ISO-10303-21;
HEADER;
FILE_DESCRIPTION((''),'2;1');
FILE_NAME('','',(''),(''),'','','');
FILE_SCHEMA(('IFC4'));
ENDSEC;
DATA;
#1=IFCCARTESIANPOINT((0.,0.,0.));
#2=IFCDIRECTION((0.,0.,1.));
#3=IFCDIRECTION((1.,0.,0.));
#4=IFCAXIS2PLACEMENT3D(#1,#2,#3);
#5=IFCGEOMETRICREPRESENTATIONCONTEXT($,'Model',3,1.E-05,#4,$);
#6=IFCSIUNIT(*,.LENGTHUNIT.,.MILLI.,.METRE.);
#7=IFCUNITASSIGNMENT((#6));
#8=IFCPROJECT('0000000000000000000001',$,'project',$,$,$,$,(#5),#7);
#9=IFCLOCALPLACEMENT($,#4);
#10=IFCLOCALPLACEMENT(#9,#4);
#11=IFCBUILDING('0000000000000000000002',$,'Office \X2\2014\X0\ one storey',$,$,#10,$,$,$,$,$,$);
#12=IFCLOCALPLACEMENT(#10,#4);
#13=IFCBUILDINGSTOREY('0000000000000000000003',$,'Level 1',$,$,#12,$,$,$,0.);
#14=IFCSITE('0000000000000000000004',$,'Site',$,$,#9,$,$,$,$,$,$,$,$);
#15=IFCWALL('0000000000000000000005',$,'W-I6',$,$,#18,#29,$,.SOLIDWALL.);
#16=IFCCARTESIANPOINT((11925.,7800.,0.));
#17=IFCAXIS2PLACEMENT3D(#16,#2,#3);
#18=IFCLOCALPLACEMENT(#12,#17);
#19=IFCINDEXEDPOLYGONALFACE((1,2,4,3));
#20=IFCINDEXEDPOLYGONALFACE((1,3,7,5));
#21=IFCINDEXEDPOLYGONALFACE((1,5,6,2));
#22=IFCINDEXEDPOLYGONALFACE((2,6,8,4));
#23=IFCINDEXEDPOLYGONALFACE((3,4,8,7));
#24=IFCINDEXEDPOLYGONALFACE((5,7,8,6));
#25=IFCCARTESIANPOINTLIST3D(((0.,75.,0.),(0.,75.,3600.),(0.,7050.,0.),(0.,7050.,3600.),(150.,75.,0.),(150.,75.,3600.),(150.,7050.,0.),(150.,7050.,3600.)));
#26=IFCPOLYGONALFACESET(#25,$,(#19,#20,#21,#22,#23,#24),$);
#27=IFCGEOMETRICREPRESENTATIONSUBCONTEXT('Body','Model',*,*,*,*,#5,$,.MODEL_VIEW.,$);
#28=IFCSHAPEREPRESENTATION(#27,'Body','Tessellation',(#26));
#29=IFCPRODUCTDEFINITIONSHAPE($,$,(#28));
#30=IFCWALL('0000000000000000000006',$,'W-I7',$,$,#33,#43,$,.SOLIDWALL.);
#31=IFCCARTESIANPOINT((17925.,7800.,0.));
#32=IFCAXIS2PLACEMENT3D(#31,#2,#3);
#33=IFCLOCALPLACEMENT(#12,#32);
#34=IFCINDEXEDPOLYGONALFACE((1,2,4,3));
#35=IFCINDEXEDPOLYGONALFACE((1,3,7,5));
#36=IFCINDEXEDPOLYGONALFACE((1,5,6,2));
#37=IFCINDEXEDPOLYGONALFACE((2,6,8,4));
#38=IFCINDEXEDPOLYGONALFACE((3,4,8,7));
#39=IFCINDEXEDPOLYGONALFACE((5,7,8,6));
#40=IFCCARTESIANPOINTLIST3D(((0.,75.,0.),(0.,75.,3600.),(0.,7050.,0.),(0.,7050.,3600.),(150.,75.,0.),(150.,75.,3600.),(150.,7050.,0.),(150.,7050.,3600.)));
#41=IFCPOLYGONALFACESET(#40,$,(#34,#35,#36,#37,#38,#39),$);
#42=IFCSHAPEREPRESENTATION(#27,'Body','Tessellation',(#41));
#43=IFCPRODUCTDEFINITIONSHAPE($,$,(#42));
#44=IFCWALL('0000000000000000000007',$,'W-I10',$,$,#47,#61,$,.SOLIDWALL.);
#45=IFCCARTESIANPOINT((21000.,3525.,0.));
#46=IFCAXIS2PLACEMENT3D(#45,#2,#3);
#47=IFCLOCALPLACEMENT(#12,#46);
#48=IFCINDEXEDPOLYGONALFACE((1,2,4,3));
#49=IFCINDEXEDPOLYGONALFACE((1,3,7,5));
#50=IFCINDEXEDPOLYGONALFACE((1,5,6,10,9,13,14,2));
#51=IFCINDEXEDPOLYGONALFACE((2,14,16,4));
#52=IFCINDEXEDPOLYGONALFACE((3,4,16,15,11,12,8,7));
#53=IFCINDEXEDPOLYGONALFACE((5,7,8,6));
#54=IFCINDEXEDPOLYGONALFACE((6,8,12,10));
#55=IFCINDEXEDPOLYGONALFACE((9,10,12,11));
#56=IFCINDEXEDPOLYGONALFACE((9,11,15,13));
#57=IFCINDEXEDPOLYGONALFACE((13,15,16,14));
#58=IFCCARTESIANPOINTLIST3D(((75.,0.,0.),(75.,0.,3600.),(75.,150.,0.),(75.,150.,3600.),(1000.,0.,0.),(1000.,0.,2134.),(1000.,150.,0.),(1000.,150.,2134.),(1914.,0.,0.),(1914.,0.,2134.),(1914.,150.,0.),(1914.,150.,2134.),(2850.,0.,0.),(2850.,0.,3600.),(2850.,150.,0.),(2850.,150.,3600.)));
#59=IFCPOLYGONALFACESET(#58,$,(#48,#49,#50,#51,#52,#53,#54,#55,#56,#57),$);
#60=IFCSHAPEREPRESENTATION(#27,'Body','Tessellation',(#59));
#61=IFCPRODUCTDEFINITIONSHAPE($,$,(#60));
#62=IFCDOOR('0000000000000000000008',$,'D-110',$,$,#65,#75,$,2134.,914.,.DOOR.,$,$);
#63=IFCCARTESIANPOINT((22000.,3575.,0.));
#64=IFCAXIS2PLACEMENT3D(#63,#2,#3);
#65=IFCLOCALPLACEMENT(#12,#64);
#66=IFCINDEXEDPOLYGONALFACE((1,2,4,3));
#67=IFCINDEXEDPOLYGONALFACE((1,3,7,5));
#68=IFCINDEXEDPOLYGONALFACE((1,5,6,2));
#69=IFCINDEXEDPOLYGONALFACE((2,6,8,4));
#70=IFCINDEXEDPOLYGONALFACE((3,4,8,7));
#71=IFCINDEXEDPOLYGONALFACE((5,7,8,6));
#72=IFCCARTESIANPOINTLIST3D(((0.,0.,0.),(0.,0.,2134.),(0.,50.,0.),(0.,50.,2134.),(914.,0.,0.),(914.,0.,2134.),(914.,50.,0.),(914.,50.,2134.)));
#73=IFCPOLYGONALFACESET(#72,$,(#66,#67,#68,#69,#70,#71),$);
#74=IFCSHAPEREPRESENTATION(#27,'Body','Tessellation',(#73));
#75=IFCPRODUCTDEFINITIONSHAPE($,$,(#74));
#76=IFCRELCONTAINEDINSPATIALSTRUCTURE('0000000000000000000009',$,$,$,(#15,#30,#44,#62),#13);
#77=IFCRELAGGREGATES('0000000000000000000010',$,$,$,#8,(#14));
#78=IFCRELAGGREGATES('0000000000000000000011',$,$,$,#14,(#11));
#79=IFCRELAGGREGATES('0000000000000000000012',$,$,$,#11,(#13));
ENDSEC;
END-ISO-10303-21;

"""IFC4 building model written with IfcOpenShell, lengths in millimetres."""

from ifc_helpers import new_model, si_unit, frame, frame_2d, origin, origin_with_axes, place, context, subcontext, project, spatial, rectangle, extrude, element, fill, save


model = new_model("IFC4")

# Units and contexts
model_context = context("Model", 3, precision=1e-05, world=origin_with_axes())
body_context = subcontext(model_context, "Body", "Model", "MODEL_VIEW")
ifc_project = project(units=[si_unit("LENGTHUNIT", "METRE", prefix="MILLI")], contexts=[model_context])

# Site, building, storey
site_placement = place(None, origin_with_axes())
site = spatial("IfcSite", under=ifc_project, at=site_placement, Name="Site")
building_placement = place(site_placement, origin_with_axes())
building = spatial("IfcBuilding", under=site, at=building_placement, Name="Office — one storey")
storey_placement = place(building_placement, origin_with_axes())
storey = spatial("IfcBuildingStorey", under=building, at=storey_placement, Name="Level 1", Elevation=0.0)

# Walls
for number, where, z_axis, x_axis, name in (
    (1, (11925.0, 7800.0, 0.0), (0.0, 0.0, 1.0), (1.0, 0.0, 0.0), "W-I6"),
    (2, (17925.0, 7800.0, 0.0), (0.0, 0.0, 1.0), (1.0, 0.0, 0.0), "W-I7"),
):
    element("IfcWall", number, at=place(storey_placement, frame(where, z_axis=z_axis, x_axis=x_axis)), inside=storey, Name=name, PredefinedType="SOLIDWALL", context=body_context, shape_type="SweptSolid", body=[
        extrude(rectangle(XDim=150.0, YDim=6975.0, at=frame_2d((75.0, 3562.5))), origin(), (0.0, 0.0, 1.0), 3600.0),
    ])

# Wall, opening, door
wall_1_placement = place(storey_placement, frame((21000.0, 3525.0, 0.0), z_axis=(0.0, 0.0, 1.0), x_axis=(1.0, 0.0, 0.0)))
wall_1 = element("IfcWall", 3, at=wall_1_placement, inside=storey, Name="W-I10", PredefinedType="SOLIDWALL", context=body_context, shape_type="SweptSolid", body=[
    extrude(rectangle(XDim=2775.0, YDim=150.0, at=frame_2d((1462.5, 75.0))), origin(), (0.0, 0.0, 1.0), 3600.0),
])
opening_1_placement = place(wall_1_placement, frame((1000.0, -10.0, 0.0), z_axis=(0.0, 0.0, 1.0), x_axis=(1.0, 0.0, 0.0)))
opening_1 = element("IfcOpeningElement", 4, at=opening_1_placement, cuts=wall_1, context=body_context, shape_type="SweptSolid", body=[
    extrude(rectangle(XDim=914.0, YDim=170.0, at=frame_2d((457.0, 85.0))), origin(), (0.0, 0.0, 1.0), 2134.0),
])
door_1_placement = place(storey_placement, frame((22000.0, 3575.0, 0.0), z_axis=(0.0, 0.0, 1.0), x_axis=(1.0, 0.0, 0.0)))
door_1 = element("IfcDoor", 5, at=door_1_placement, inside=storey, Name="D-110", OverallHeight=2134.0, OverallWidth=914.0, PredefinedType="DOOR", context=body_context, shape_type="SweptSolid", body=[
    extrude(rectangle(XDim=914.0, YDim=50.0, at=frame_2d((457.0, 25.0))), origin(), (0.0, 0.0, 1.0), 2134.0),
])
fill(opening_1, door_1)

save(model, "model.ifc")
